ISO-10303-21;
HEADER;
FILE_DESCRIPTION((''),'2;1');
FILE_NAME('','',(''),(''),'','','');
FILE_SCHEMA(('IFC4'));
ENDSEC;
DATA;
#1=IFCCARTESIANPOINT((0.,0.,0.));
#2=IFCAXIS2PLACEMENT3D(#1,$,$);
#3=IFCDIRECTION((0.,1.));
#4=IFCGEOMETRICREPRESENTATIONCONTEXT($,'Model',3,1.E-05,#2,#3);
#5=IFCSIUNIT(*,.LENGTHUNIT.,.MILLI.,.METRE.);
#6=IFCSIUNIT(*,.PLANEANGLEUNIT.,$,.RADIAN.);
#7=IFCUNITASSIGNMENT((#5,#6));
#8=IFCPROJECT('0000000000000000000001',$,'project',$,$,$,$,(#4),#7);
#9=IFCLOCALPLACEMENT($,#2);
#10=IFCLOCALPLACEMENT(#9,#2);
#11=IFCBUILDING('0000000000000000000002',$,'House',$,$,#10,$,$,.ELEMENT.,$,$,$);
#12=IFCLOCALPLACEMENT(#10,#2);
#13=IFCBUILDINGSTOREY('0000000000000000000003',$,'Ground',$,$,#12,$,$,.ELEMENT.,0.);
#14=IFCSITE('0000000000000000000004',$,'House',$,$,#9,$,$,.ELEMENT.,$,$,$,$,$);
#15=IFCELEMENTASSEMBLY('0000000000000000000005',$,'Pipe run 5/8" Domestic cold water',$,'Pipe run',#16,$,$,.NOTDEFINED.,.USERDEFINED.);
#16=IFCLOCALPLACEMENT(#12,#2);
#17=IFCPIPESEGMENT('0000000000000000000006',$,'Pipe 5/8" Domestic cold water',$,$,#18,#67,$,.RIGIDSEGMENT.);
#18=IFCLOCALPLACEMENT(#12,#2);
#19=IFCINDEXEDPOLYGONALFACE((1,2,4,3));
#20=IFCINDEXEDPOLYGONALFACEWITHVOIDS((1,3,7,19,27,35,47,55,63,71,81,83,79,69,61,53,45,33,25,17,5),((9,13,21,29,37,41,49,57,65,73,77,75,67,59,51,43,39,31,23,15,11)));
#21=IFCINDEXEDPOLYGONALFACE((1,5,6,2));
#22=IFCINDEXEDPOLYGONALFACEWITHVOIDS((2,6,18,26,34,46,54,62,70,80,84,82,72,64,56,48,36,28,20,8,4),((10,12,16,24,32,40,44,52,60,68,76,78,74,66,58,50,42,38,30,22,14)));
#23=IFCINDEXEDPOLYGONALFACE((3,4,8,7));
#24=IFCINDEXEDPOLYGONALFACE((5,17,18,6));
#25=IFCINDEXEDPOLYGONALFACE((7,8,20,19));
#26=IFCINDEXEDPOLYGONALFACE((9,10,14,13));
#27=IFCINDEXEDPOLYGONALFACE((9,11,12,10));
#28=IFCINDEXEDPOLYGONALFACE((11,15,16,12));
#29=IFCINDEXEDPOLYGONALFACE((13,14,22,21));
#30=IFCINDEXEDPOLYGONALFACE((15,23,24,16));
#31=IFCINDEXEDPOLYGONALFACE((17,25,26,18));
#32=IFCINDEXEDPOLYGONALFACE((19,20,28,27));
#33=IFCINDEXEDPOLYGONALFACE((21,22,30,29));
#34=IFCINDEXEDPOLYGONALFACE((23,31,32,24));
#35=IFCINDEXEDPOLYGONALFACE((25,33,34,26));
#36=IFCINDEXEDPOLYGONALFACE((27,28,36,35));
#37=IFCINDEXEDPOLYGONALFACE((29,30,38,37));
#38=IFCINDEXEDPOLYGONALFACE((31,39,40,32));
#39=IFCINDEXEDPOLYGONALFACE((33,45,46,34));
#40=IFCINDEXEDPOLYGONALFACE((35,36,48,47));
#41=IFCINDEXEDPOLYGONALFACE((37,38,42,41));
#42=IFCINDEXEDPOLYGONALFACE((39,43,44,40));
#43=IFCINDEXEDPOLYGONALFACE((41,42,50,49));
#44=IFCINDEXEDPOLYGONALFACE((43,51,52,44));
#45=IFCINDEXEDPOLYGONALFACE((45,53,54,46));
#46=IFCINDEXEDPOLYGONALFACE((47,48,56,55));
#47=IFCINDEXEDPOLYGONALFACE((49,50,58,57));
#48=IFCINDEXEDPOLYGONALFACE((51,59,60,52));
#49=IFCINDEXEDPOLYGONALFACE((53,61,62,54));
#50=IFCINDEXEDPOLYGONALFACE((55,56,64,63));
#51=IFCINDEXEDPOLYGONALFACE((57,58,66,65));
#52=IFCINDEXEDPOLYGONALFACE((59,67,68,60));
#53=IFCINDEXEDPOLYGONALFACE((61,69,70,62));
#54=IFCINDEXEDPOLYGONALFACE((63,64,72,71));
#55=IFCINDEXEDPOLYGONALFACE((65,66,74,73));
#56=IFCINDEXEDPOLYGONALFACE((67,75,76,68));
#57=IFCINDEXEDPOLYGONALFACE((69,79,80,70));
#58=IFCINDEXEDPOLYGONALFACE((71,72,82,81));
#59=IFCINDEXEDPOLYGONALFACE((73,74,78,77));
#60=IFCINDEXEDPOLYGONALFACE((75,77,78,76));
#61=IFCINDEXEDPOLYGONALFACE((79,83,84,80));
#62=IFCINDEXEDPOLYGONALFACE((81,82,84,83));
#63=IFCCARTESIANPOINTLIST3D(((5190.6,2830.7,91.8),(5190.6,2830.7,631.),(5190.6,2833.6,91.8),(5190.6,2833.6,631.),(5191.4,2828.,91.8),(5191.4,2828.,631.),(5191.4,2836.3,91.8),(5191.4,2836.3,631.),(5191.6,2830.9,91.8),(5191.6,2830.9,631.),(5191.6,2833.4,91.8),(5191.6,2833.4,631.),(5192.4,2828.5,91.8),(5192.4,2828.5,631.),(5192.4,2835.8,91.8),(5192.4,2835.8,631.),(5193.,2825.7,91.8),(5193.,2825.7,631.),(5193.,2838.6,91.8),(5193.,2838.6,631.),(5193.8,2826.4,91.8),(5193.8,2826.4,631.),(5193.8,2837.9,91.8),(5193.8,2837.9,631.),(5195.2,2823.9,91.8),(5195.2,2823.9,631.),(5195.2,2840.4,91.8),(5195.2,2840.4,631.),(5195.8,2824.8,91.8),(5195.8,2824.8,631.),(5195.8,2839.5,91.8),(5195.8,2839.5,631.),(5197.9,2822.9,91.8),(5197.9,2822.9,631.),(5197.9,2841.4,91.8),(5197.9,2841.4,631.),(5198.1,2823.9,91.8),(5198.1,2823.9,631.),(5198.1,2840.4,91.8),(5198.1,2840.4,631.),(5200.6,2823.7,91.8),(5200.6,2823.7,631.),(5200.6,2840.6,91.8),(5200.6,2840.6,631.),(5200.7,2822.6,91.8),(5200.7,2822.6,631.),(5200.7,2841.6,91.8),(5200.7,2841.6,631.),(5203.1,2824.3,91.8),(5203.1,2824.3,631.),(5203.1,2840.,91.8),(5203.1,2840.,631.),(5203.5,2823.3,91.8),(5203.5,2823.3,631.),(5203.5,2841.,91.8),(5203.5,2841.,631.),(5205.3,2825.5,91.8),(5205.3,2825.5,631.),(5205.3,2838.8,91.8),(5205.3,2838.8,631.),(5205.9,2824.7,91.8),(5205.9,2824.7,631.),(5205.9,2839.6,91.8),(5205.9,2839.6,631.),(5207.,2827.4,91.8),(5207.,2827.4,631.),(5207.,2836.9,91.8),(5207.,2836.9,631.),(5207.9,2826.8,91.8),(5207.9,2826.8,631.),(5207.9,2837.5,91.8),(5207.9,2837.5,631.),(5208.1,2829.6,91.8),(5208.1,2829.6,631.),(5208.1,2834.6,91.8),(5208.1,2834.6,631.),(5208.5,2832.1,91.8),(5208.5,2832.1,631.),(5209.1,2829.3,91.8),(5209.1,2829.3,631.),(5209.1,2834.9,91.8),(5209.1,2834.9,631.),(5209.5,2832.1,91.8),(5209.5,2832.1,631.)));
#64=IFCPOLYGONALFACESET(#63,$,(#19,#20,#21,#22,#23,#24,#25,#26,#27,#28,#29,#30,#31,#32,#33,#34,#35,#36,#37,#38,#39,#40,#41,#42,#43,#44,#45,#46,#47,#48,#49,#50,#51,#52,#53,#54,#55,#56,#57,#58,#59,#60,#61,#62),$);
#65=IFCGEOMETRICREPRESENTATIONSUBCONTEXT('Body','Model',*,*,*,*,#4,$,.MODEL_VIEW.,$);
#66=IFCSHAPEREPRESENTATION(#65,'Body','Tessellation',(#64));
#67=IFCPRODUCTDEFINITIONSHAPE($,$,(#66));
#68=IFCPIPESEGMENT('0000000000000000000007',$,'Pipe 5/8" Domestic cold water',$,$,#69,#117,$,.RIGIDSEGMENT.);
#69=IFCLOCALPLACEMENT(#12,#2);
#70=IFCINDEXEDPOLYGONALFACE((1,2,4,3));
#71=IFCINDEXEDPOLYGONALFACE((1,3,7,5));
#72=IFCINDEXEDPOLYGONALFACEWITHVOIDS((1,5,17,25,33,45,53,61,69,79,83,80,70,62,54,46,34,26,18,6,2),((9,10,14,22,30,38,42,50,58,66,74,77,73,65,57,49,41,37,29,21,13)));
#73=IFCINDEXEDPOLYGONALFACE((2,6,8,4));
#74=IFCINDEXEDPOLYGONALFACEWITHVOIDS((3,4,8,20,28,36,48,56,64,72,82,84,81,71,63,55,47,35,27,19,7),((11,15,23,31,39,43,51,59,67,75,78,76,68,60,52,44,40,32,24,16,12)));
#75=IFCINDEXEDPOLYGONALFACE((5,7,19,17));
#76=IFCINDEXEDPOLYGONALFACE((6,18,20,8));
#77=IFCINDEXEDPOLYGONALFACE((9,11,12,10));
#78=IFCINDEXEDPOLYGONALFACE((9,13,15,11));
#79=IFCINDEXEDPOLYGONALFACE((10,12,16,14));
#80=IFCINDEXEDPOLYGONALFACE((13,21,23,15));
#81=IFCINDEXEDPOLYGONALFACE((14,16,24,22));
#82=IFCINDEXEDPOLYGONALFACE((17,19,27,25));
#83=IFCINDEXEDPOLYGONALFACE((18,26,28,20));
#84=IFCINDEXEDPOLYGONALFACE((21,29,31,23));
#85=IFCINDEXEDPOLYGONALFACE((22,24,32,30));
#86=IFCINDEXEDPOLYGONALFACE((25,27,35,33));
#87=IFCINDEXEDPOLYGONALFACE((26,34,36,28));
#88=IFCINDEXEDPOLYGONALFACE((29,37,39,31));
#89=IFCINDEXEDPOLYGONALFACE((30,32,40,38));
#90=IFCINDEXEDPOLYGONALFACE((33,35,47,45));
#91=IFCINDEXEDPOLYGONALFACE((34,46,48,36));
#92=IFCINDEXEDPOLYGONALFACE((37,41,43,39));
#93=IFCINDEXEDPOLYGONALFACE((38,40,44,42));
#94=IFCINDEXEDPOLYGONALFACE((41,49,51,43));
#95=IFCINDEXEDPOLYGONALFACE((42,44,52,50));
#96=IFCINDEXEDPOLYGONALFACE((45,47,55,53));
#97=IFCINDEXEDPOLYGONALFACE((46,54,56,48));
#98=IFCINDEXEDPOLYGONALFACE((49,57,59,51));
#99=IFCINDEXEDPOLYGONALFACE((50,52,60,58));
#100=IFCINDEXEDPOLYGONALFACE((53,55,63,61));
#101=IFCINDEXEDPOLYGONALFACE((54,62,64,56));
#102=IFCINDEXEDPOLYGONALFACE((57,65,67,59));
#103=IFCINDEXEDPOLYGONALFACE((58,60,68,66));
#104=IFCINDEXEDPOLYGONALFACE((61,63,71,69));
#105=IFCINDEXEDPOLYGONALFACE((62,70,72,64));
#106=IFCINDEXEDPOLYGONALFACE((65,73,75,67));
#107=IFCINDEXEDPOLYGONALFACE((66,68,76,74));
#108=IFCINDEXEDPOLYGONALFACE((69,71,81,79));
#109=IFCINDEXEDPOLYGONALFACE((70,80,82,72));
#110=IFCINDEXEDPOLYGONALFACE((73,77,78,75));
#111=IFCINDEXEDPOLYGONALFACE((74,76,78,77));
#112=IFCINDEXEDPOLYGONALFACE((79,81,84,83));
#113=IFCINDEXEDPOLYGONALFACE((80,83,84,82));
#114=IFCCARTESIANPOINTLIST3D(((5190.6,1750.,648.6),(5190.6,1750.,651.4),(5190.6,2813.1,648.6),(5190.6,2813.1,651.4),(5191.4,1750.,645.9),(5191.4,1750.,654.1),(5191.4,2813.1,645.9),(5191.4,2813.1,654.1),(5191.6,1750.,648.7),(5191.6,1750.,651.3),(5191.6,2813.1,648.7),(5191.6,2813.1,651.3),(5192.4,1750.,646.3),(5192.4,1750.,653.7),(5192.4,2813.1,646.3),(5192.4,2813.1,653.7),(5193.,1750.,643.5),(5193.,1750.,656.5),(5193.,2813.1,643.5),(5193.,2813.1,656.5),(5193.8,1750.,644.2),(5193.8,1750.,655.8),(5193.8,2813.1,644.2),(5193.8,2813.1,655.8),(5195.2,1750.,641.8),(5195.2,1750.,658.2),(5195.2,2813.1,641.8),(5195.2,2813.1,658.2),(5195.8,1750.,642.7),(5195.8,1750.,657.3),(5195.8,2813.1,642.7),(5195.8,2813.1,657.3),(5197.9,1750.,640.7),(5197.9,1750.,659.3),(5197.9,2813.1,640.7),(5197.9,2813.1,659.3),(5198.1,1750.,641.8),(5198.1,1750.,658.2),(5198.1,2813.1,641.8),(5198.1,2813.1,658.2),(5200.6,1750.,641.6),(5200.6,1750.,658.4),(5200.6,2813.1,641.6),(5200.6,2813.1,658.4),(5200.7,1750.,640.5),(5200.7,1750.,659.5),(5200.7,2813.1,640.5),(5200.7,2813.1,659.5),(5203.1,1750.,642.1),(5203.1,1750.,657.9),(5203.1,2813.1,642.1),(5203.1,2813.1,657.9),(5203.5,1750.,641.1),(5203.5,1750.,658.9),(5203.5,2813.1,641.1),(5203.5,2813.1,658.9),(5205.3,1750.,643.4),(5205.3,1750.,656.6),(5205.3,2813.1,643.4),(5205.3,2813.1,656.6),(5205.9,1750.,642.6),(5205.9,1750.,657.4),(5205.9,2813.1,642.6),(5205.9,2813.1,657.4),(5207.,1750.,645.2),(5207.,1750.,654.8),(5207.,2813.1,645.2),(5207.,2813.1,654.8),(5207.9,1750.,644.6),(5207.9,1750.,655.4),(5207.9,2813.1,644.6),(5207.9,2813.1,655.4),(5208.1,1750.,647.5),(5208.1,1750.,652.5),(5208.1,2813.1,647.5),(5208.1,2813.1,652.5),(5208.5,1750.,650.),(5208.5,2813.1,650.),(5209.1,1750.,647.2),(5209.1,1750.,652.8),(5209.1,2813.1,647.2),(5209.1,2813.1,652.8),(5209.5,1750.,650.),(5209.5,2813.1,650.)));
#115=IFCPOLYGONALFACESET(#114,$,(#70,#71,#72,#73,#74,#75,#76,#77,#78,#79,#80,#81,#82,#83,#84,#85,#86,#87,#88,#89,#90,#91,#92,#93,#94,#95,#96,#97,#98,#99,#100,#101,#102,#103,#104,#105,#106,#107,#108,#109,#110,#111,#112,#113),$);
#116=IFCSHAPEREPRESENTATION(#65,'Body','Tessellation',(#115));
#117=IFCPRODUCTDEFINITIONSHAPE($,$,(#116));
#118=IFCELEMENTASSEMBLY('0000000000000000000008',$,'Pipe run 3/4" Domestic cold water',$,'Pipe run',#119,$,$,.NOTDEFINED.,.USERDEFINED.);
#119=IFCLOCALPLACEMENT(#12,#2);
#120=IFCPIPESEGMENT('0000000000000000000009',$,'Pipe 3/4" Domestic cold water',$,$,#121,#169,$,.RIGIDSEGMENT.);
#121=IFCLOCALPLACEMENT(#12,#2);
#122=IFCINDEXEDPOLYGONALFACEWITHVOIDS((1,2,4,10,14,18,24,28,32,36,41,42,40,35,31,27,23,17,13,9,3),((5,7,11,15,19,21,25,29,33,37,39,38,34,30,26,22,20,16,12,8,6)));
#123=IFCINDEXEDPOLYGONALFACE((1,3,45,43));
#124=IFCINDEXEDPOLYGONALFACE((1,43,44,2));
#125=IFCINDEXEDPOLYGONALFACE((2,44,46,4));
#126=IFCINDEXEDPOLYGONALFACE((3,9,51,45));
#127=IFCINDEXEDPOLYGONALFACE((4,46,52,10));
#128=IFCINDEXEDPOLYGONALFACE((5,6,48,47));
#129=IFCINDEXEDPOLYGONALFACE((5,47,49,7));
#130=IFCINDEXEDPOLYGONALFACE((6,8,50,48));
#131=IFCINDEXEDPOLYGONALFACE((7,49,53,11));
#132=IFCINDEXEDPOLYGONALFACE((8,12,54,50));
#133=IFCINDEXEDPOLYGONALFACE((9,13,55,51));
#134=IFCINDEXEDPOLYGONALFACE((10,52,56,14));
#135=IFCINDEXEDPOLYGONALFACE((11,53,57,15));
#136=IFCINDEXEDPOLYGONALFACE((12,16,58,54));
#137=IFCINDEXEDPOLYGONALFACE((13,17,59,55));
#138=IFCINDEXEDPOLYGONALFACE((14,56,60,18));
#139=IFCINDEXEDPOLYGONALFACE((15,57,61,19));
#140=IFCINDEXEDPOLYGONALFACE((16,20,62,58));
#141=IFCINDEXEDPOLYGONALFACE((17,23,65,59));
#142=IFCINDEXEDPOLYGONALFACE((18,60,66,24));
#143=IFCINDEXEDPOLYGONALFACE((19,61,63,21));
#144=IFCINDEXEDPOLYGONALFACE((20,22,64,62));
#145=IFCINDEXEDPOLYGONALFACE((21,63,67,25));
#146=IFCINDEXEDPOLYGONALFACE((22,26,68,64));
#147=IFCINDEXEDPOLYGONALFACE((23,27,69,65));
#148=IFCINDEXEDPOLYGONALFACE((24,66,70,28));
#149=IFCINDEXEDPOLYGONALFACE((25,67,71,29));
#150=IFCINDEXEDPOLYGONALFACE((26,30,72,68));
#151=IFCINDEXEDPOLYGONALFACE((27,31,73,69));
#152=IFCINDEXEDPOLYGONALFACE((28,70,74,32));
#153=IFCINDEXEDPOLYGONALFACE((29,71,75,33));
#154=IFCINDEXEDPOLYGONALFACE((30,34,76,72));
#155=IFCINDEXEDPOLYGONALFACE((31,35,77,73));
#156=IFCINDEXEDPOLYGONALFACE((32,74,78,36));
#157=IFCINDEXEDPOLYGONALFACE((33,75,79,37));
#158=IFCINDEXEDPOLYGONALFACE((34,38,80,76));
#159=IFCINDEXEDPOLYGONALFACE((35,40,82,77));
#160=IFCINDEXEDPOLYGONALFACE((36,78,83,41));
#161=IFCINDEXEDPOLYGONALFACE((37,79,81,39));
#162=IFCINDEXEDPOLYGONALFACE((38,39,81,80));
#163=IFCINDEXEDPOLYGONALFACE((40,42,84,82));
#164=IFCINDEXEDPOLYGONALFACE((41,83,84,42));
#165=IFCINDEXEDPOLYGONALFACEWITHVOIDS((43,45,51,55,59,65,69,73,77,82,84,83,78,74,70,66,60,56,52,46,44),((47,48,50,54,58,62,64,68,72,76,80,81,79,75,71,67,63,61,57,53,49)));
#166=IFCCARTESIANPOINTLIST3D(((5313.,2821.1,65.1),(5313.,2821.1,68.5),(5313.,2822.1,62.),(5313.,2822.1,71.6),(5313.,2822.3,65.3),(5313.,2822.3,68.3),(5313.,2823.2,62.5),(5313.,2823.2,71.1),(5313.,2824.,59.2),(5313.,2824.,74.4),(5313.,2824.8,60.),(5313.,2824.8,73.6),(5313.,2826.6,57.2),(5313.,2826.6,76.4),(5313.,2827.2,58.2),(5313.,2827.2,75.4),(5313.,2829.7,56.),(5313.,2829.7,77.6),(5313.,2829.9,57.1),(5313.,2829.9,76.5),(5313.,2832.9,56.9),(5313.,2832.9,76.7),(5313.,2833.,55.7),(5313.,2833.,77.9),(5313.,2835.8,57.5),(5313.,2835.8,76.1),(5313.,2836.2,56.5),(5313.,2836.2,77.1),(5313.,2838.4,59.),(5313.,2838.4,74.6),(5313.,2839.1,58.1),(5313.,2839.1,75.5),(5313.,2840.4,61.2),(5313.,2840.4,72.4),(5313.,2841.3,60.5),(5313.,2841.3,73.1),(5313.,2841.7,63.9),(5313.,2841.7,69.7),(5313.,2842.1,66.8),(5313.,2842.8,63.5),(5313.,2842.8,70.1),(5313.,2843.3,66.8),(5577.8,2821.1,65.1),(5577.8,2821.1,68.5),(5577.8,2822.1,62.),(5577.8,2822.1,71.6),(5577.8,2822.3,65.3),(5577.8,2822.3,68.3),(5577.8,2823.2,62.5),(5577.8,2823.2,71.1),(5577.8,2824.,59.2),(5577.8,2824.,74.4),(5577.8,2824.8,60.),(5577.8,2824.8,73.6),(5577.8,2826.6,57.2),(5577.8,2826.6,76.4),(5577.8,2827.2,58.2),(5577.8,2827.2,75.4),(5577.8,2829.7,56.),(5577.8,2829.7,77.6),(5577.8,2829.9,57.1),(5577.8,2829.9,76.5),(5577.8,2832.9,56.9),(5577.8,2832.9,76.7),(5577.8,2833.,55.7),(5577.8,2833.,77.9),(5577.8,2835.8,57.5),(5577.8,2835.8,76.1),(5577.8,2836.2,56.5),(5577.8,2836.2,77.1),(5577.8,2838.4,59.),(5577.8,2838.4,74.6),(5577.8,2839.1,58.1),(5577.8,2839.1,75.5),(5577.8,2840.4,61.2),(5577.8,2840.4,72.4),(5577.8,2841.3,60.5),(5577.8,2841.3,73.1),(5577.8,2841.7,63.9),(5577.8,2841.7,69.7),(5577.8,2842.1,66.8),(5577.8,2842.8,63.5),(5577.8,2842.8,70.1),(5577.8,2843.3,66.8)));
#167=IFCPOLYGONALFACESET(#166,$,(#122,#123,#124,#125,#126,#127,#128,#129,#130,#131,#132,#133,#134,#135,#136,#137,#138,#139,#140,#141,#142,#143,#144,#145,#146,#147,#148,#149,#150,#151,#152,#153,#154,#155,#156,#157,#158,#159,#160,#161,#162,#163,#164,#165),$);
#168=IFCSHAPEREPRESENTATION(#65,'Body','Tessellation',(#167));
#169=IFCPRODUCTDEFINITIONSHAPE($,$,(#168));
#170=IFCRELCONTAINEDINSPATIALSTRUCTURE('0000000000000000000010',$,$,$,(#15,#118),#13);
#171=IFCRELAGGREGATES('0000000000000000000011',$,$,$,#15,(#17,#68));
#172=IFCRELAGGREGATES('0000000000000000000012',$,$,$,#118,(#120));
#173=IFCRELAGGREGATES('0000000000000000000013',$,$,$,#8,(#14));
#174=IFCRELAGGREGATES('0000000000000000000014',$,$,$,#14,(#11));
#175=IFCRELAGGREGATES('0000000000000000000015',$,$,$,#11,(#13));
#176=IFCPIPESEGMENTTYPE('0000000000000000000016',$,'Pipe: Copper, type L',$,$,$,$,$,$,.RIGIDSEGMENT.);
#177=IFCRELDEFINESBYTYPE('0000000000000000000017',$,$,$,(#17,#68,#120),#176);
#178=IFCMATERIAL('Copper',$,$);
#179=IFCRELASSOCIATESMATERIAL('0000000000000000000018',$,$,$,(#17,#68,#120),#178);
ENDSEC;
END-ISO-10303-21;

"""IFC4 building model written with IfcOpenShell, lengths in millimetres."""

from ifc_helpers import new_model, si_unit, direction, frame, origin, origin_with_axes, origin_2d, place, context, subcontext, project, spatial, hollow_circle, extrude, material, type_object, element, aggregate, save


model = new_model("IFC4")

# Units and contexts
model_context = context("Model", 3, precision=1e-05, world=origin(), true_north=direction((0.0, 1.0)))
body_context = subcontext(model_context, "Body", "Model", "MODEL_VIEW")
ifc_project = project(units=[si_unit("LENGTHUNIT", "METRE", prefix="MILLI"), si_unit("PLANEANGLEUNIT", "RADIAN")], contexts=[model_context])

# Site, building, storey
site_placement = place(None, origin())
site = spatial("IfcSite", under=ifc_project, at=site_placement, Name="House", CompositionType="ELEMENT")
building_placement = place(site_placement, origin())
building = spatial("IfcBuilding", under=site, at=building_placement, Name="House", CompositionType="ELEMENT")
storey_placement = place(building_placement, origin())
storey = spatial("IfcBuildingStorey", under=building, at=storey_placement, Name="Ground", CompositionType="ELEMENT", Elevation=0.0)

# Element assemblies, pipe segments
assembly_1_placement = place(storey_placement, origin_with_axes())
assembly_1 = element("IfcElementAssembly", 1, at=assembly_1_placement, inside=storey, Name="Pipe run 5/8\" Domestic cold water", ObjectType="Pipe run", AssemblyPlace="NOTDEFINED", PredefinedType="USERDEFINED")
ifc_material = material(Name="Copper")
pipe_segment_type = type_object("IfcPipeSegmentType", Name="Pipe: Copper, type L", PredefinedType="RIGIDSEGMENT")
pipe_segment_1_placement = place(storey_placement, origin_with_axes())
pipe_segment_1 = element("IfcPipeSegment", 2, at=pipe_segment_1_placement, type_object=pipe_segment_type, material=ifc_material, Name="Pipe 5/8\" Domestic cold water", PredefinedType="RIGIDSEGMENT", context=body_context, shape_type="SweptSolid", body=[
    extrude(hollow_circle(Radius=9.5, WallThickness=1.1, at=origin_2d()), frame((5200.0, 2832.1, 91.8), z_axis=(0.0, 0.0, 1.0), x_axis=(1.0, 0.0, 0.0)), (0.0, 0.0, 1.0), 539.1),
])
pipe_segment_2_placement = place(storey_placement, origin_with_axes())
pipe_segment_2 = element("IfcPipeSegment", 3, at=pipe_segment_2_placement, type_object=pipe_segment_type, material=ifc_material, Name="Pipe 5/8\" Domestic cold water", PredefinedType="RIGIDSEGMENT", context=body_context, shape_type="SweptSolid", body=[
    extrude(hollow_circle(Radius=9.5, WallThickness=1.1, at=origin_2d()), frame((5200.0, 2813.1, 650.0), z_axis=(0.0, -1.0, 0.0), x_axis=(1.0, 0.0, 0.0)), (0.0, 0.0, 1.0), 1063.1),
])
assembly_2_placement = place(storey_placement, origin_with_axes())
assembly_2 = element("IfcElementAssembly", 4, at=assembly_2_placement, inside=storey, Name="Pipe run 3/4\" Domestic cold water", ObjectType="Pipe run", AssemblyPlace="NOTDEFINED", PredefinedType="USERDEFINED")
pipe_segment_3_placement = place(storey_placement, origin_with_axes())
pipe_segment_3 = element("IfcPipeSegment", 5, at=pipe_segment_3_placement, type_object=pipe_segment_type, material=ifc_material, Name="Pipe 3/4\" Domestic cold water", PredefinedType="RIGIDSEGMENT", context=body_context, shape_type="SweptSolid", body=[
    extrude(hollow_circle(Radius=11.1, WallThickness=1.1, at=origin_2d()), frame((5313.0, 2832.1, 66.8), z_axis=(1.0, 0.0, 0.0), x_axis=(0.0, 1.0, 0.0)), (0.0, 0.0, 1.0), 264.8),
])

aggregate(assembly_1, [pipe_segment_1, pipe_segment_2])

aggregate(assembly_2, [pipe_segment_3])

save(model, "model.ifc")
